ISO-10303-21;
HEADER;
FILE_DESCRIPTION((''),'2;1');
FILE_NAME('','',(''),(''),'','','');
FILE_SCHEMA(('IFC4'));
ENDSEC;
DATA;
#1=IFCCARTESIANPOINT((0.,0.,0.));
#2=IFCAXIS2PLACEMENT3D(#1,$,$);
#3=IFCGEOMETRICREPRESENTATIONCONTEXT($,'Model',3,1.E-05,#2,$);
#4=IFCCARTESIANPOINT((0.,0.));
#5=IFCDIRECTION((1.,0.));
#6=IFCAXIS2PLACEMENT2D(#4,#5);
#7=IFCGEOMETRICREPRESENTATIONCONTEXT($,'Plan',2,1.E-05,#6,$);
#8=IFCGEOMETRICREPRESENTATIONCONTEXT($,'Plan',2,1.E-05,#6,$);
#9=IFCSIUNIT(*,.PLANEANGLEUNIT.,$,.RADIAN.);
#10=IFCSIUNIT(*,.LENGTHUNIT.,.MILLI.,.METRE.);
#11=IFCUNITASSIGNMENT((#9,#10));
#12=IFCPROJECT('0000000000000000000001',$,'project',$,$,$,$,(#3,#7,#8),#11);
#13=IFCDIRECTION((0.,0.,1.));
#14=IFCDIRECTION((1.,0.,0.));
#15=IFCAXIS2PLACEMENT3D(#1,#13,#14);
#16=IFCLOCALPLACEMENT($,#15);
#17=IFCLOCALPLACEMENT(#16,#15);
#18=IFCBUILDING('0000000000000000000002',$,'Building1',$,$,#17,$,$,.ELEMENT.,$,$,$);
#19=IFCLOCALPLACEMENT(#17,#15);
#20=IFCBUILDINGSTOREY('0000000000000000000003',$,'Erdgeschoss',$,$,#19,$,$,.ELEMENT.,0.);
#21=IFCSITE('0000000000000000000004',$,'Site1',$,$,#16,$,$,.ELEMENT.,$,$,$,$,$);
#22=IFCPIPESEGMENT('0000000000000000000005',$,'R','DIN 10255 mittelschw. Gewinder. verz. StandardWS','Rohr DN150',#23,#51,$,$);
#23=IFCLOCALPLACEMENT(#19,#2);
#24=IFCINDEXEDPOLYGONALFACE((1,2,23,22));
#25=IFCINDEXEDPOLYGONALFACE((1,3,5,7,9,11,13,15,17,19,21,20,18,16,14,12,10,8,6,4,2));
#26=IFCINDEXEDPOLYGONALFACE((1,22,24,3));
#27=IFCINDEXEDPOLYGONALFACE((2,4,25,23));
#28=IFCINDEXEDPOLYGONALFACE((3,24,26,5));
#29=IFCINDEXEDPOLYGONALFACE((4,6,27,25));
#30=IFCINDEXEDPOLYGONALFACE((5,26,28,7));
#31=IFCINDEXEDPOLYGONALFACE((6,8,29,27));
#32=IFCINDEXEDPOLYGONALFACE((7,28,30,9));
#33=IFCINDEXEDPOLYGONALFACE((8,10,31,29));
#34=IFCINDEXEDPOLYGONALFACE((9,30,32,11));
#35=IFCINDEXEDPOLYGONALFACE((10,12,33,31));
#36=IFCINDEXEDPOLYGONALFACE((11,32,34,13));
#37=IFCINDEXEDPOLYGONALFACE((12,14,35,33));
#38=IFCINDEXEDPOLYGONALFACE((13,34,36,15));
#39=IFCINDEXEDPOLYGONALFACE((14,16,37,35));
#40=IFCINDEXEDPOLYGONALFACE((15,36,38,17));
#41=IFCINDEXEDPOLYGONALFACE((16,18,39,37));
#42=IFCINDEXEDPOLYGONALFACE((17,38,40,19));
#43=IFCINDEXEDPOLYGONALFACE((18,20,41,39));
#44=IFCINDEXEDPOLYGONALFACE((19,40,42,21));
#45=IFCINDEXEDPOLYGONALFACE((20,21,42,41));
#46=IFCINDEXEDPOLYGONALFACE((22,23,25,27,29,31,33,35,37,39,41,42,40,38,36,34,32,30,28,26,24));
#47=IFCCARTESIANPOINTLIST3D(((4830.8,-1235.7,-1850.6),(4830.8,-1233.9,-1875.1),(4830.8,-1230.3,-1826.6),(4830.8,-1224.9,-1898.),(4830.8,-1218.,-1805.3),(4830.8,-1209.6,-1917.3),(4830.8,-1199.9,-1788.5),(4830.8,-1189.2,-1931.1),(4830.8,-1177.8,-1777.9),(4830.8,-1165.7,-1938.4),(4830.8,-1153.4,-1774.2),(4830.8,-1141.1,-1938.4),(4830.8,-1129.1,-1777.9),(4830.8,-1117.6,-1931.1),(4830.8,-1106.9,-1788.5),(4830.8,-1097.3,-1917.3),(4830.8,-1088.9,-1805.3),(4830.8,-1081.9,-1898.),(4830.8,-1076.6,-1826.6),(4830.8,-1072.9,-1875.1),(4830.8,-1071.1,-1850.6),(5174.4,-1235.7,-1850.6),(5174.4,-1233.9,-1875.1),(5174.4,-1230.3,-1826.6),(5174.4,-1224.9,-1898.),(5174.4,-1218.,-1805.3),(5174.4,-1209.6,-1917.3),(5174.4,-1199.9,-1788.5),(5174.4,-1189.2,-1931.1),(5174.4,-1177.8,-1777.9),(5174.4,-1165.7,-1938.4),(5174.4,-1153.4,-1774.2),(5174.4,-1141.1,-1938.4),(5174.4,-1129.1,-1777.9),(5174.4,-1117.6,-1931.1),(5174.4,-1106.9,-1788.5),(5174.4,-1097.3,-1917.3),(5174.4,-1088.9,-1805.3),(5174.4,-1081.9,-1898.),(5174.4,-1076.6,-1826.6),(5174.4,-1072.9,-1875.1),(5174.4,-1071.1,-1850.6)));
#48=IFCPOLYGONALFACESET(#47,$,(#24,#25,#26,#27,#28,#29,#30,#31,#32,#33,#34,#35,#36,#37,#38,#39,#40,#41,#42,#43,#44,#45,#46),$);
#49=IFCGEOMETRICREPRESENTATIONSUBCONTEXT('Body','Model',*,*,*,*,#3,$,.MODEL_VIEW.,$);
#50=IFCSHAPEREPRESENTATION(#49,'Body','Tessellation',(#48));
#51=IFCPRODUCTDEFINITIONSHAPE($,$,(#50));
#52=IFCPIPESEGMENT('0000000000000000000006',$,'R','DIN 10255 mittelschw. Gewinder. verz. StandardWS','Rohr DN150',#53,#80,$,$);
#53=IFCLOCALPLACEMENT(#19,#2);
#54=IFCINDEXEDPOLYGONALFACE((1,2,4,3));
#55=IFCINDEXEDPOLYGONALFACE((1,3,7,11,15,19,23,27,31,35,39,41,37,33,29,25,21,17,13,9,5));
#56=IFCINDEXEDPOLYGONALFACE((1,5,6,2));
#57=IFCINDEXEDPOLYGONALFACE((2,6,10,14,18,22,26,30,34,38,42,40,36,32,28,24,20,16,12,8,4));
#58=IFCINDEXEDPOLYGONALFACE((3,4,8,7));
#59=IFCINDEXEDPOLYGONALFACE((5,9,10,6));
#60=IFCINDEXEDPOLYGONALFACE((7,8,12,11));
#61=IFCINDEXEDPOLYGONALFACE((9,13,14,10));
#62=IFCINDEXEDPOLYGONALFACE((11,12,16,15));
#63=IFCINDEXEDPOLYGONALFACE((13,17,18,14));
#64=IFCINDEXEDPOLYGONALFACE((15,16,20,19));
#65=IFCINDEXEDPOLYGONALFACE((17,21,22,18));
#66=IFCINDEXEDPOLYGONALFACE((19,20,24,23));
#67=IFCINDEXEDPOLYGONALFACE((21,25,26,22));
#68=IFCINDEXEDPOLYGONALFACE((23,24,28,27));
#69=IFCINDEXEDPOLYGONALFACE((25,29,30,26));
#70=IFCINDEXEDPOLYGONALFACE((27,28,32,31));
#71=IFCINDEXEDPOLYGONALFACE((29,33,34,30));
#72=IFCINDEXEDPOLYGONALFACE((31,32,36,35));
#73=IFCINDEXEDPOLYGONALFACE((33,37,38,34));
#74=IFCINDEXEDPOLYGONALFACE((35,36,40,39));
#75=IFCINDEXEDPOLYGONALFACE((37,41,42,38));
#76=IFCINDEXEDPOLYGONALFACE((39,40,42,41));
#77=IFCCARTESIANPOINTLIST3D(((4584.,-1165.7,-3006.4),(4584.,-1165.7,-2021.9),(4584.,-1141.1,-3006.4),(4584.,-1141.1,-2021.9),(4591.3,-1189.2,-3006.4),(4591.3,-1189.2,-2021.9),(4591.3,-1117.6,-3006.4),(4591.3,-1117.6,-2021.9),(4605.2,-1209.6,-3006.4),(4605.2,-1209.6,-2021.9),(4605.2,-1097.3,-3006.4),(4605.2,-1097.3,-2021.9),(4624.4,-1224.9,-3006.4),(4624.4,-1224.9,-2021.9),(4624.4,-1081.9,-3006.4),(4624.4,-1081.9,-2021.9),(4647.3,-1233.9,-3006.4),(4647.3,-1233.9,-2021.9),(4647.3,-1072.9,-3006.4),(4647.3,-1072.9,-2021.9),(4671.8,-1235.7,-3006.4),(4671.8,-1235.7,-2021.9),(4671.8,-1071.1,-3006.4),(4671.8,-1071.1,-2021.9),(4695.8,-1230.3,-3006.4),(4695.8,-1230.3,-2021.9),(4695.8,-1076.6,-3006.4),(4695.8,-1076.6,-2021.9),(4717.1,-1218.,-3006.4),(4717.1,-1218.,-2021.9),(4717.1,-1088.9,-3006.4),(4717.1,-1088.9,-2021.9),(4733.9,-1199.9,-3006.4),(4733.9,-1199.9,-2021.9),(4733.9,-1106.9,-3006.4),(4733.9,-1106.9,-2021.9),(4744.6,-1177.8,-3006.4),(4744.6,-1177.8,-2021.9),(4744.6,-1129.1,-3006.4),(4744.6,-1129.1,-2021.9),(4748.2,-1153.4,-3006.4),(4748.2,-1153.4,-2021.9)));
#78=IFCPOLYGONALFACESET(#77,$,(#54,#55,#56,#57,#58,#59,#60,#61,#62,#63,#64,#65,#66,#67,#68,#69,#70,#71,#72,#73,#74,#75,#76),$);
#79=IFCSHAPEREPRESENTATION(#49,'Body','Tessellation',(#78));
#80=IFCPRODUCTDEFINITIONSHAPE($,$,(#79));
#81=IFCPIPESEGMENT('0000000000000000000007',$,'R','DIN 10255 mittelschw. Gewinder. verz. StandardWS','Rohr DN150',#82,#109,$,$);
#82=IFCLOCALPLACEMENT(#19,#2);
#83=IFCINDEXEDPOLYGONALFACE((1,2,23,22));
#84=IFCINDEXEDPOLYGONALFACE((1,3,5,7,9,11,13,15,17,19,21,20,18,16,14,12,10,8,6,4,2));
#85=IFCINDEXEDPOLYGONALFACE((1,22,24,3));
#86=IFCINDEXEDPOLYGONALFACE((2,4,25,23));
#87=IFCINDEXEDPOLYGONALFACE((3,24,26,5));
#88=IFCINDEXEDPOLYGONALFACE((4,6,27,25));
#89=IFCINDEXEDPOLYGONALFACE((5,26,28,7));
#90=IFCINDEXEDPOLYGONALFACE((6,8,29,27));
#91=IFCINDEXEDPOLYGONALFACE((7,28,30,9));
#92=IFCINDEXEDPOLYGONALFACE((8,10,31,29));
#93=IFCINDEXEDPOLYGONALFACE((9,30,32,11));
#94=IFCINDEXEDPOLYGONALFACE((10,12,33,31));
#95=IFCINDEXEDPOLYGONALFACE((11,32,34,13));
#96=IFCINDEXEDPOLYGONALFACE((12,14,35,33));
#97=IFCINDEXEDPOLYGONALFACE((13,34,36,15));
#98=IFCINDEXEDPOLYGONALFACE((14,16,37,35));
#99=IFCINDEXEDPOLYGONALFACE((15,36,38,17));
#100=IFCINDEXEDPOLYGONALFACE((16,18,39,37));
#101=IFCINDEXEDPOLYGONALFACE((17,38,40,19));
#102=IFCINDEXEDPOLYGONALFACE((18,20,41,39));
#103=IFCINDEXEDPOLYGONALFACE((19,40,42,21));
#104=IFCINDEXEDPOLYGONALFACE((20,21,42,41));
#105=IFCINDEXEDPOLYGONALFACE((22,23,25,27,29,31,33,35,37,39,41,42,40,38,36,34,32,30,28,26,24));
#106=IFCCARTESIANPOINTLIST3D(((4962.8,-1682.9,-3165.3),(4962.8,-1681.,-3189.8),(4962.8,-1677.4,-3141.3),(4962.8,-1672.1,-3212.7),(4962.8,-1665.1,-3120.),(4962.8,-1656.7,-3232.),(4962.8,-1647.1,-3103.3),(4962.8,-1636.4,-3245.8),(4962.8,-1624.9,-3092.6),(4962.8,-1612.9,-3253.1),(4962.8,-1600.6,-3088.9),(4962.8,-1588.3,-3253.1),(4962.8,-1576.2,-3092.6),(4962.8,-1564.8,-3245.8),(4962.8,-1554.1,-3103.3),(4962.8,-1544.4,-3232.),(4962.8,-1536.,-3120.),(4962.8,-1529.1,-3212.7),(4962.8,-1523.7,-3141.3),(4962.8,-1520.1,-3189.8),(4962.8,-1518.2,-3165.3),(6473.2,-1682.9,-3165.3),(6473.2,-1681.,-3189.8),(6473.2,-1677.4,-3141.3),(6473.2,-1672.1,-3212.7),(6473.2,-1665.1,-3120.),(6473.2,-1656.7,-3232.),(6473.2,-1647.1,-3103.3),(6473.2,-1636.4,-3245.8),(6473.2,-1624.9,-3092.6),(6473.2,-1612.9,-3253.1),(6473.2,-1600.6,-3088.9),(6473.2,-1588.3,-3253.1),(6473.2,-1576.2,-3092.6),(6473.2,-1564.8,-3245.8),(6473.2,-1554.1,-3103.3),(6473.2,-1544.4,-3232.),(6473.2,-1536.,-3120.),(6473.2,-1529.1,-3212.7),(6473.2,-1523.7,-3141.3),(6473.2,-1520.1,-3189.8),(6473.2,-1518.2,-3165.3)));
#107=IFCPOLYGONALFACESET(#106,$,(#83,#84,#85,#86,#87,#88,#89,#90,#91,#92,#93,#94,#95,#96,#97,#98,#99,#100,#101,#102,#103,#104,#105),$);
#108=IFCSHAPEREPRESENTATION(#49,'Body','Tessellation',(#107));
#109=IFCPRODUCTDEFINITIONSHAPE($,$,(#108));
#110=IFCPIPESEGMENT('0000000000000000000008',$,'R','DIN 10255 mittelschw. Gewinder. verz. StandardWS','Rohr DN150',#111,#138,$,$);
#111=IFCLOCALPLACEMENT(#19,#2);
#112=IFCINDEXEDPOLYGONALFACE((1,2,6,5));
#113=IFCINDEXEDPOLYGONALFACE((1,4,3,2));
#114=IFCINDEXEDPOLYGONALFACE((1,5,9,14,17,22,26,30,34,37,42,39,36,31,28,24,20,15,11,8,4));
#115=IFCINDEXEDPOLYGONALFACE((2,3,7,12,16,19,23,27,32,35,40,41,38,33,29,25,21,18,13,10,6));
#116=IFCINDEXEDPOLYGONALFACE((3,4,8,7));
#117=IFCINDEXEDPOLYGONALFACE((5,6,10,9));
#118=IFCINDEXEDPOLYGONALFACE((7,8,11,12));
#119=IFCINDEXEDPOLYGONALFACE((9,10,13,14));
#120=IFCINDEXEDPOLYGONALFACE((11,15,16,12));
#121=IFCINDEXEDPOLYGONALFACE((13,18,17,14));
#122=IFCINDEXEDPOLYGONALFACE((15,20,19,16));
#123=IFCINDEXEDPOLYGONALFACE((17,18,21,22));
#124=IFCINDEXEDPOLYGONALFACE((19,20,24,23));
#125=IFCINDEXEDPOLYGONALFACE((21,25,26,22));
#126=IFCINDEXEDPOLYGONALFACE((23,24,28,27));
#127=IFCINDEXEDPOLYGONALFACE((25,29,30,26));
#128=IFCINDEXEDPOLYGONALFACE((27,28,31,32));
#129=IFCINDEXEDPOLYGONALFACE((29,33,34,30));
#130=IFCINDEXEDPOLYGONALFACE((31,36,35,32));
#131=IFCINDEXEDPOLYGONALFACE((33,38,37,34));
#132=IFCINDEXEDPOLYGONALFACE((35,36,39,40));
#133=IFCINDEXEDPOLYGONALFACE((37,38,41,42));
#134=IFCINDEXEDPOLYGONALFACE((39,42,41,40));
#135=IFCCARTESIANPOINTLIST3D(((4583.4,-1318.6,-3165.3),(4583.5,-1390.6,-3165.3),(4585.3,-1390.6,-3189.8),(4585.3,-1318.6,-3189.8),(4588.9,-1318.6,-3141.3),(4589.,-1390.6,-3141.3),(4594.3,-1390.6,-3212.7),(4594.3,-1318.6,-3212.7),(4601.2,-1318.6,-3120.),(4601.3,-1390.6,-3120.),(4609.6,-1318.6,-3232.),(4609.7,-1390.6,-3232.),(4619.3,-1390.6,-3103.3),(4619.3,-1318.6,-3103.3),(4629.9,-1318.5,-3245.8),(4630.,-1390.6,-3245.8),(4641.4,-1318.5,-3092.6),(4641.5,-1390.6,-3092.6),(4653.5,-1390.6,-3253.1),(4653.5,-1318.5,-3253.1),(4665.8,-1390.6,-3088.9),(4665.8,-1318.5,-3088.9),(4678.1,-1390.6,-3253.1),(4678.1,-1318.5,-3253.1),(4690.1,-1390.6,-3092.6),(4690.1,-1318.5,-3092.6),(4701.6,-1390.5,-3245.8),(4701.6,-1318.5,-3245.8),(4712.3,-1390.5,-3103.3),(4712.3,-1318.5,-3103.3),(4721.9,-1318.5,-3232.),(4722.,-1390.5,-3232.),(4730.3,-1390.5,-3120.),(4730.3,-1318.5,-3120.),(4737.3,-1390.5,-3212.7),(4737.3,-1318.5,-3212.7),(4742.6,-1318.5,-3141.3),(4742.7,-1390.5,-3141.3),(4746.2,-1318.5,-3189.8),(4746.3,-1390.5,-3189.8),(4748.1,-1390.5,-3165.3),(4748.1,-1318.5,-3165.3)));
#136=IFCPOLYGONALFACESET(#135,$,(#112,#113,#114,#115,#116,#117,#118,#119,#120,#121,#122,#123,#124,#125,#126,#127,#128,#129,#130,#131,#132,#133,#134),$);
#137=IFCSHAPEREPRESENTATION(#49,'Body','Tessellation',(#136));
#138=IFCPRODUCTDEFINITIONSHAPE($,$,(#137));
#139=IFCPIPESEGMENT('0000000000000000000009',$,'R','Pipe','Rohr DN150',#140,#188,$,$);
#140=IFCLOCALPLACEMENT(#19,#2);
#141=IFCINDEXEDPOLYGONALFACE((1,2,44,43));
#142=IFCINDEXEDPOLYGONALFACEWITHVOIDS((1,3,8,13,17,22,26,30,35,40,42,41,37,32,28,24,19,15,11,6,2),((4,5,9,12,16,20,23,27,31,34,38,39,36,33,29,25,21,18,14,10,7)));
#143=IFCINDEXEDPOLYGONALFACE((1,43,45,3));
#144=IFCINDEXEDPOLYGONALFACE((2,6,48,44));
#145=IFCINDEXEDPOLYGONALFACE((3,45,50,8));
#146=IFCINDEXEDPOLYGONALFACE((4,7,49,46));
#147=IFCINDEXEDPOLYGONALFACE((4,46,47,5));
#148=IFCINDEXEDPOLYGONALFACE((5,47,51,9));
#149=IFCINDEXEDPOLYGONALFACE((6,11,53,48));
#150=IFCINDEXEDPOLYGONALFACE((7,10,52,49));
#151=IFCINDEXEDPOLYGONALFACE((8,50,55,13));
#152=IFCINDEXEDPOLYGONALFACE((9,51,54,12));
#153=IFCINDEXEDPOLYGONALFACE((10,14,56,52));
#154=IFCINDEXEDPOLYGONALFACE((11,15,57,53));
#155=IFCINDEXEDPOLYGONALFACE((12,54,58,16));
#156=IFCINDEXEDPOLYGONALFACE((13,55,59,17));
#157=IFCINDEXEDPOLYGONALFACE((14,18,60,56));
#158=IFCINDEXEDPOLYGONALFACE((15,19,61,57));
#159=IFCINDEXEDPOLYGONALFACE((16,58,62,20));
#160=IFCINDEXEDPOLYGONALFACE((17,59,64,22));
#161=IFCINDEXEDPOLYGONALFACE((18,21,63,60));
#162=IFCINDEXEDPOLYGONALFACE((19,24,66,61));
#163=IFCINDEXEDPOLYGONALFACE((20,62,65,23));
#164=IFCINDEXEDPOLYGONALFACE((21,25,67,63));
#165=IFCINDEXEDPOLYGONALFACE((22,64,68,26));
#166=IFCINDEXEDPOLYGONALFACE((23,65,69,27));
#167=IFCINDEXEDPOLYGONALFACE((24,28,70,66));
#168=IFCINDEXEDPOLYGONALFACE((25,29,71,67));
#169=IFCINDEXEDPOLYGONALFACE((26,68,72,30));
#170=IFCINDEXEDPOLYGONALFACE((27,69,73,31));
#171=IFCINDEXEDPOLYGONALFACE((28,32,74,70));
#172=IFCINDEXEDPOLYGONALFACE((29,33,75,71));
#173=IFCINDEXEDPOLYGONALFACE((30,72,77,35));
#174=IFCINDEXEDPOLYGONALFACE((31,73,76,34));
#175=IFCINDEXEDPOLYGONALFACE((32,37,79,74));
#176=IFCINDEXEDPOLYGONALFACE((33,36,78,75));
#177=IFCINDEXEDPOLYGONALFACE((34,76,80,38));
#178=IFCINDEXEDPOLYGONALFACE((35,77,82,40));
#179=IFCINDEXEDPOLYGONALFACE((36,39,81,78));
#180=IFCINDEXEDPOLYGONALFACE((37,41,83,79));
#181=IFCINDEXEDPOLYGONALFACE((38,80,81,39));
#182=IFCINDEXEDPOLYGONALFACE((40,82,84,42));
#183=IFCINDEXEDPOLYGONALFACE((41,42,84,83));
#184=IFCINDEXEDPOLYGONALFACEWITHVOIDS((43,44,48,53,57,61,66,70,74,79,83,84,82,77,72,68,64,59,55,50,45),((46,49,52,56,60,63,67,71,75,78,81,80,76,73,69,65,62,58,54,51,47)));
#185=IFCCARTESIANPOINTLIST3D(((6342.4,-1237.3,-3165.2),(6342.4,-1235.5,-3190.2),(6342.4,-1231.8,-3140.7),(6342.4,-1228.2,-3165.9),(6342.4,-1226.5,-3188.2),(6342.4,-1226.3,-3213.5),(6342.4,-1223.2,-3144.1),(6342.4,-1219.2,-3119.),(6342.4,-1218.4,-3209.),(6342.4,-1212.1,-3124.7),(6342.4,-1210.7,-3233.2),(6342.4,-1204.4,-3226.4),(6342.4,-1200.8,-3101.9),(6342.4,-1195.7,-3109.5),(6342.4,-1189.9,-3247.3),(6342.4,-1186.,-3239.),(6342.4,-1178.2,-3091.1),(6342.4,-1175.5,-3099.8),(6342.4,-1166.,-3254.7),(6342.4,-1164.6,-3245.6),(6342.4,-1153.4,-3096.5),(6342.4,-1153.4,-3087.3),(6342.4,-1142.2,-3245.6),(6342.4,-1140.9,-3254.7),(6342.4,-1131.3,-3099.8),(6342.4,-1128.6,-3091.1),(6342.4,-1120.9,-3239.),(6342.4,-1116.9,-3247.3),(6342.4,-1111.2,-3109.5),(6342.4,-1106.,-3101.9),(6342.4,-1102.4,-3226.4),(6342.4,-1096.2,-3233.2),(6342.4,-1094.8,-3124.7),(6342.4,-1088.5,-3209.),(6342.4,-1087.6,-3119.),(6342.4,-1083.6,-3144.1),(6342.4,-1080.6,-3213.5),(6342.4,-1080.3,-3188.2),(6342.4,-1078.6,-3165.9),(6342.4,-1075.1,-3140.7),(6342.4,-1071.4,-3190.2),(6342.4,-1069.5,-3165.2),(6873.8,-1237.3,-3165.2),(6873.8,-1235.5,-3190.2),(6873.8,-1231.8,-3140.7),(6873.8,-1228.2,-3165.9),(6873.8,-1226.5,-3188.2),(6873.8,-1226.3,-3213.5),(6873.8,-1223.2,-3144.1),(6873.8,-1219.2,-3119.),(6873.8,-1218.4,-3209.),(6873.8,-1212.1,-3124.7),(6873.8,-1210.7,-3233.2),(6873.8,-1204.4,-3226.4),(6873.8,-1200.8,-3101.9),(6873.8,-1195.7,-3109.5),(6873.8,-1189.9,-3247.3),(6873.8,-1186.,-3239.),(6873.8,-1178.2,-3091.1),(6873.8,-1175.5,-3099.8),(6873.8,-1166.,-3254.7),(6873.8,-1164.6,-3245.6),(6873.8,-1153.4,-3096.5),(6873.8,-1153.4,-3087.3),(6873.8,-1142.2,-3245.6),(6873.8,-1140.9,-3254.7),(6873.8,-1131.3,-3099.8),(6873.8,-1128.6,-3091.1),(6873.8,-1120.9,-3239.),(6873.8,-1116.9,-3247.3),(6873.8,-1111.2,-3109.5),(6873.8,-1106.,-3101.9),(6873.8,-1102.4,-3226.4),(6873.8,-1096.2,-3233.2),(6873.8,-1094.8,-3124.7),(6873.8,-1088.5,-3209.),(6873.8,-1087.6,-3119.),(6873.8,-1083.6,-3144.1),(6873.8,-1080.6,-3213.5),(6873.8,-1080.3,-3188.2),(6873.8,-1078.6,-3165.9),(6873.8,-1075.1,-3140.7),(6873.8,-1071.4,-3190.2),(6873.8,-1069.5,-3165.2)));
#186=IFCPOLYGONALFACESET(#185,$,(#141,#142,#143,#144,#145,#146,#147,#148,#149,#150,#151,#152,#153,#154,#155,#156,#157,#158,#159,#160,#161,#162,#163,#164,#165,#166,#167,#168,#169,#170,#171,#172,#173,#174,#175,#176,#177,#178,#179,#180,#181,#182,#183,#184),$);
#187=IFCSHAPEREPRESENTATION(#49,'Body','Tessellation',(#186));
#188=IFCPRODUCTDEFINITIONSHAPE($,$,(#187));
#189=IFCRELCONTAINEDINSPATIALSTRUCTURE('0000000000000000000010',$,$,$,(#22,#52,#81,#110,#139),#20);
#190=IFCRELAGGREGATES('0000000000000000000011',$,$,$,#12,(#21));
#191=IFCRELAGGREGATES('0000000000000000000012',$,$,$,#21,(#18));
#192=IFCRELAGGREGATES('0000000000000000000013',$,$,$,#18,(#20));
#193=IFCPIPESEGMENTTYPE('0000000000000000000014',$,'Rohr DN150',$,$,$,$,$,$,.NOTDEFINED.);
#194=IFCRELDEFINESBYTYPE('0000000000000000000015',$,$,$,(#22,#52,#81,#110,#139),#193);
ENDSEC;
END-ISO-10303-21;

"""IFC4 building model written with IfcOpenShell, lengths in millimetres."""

from ifc_helpers import new_model, si_unit, frame, origin, origin_with_axes, origin_2d_with_axis, place, context, subcontext, project, spatial, circle, hollow_circle, extrude, type_object, element, save


model = new_model("IFC4")

# Units and contexts
model_context = context("Model", 3, precision=1e-05, world=origin())
plan_context_1 = context("Plan", 2, precision=1e-05, world=origin_2d_with_axis())
plan_context_2 = context("Plan", 2, precision=1e-05, world=origin_2d_with_axis())
body_context = subcontext(model_context, "Body", "Model", "MODEL_VIEW")
ifc_project = project(units=[si_unit("PLANEANGLEUNIT", "RADIAN"), si_unit("LENGTHUNIT", "METRE", prefix="MILLI")], contexts=[model_context, plan_context_1, plan_context_2])

# Site, building, storey
site_placement = place(None, origin_with_axes())
site = spatial("IfcSite", under=ifc_project, at=site_placement, Name="Site1", CompositionType="ELEMENT")
building_placement = place(site_placement, origin_with_axes())
building = spatial("IfcBuilding", under=site, at=building_placement, Name="Building1", CompositionType="ELEMENT")
storey_placement = place(building_placement, origin_with_axes())
storey = spatial("IfcBuildingStorey", under=building, at=storey_placement, Name="Erdgeschoss", CompositionType="ELEMENT", Elevation=0.0)

# Pipe segments
pipe_segment_type_1 = type_object("IfcPipeSegmentType", Name="Rohr DN150", PredefinedType="NOTDEFINED")
pipe_segment_1_placement = place(storey_placement, frame((5002.6, -1153.6, -1856.8), z_axis=(0.0, 0.0, 1.0), x_axis=(1.0, 0.0, 0.0)))
element("IfcPipeSegment", 1, at=pipe_segment_1_placement, inside=storey, type_object=pipe_segment_type_1, Name="R", Description="DIN 10255 mittelschw. Gewinder. verz. StandardWS", ObjectType="Rohr DN150", context=body_context, shape_type="SolidModel", body=[
    extrude(circle(Radius=82.5, at=origin_2d_with_axis()), frame((171.8, 0.2, 0.0), z_axis=(-1.0, 0.0, 0.0), x_axis=(0.0, 0.0, 1.0)), (0.0, 0.0, 1.0), 343.6),
])
pipe_segment_2_placement = place(storey_placement, frame((4665.7, -1153.6, -2514.1), z_axis=(0.0, 0.0, 1.0), x_axis=(1.0, 0.0, 0.0)))
element("IfcPipeSegment", 2, at=pipe_segment_2_placement, inside=storey, type_object=pipe_segment_type_1, Name="R", Description="DIN 10255 mittelschw. Gewinder. verz. StandardWS", ObjectType="Rohr DN150", context=body_context, shape_type="SolidModel", body=[
    extrude(circle(Radius=82.5, at=origin_2d_with_axis()), frame((0.0, 0.2, -492.3), z_axis=(0.0, 0.0, 1.0), x_axis=(1.0, 0.0, 0.0)), (0.0, 0.0, 1.0), 984.5),
])
pipe_segment_3_placement = place(storey_placement, frame((5718.0, -1600.7, -3171.5), z_axis=(0.0, 0.0, 1.0), x_axis=(1.0, 0.0, 0.0)))
element("IfcPipeSegment", 3, at=pipe_segment_3_placement, inside=storey, type_object=pipe_segment_type_1, Name="R", Description="DIN 10255 mittelschw. Gewinder. verz. StandardWS", ObjectType="Rohr DN150", context=body_context, shape_type="SolidModel", body=[
    extrude(circle(Radius=82.5, at=origin_2d_with_axis()), frame((755.2, 0.1, 0.0), z_axis=(-1.0, 0.0, 0.0), x_axis=(0.0, 0.0, 1.0)), (0.0, 0.0, 1.0), 1510.4),
])
pipe_segment_4_placement = place(storey_placement, frame((4665.6, -1354.5, -3171.5), z_axis=(0.0, 0.0, 1.0), x_axis=(1.0, 0.0, 0.0)))
element("IfcPipeSegment", 4, at=pipe_segment_4_placement, inside=storey, type_object=pipe_segment_type_1, Name="R", Description="DIN 10255 mittelschw. Gewinder. verz. StandardWS", ObjectType="Rohr DN150", context=body_context, shape_type="SolidModel", body=[
    extrude(circle(Radius=82.5, at=origin_2d_with_axis()), frame((0.2, -36.0, 0.0), z_axis=(-0.000562, 1.0, 0.0), x_axis=(0.0, 0.0, 1.0)), (0.0, 0.0, 1.0), 72.0),
])
pipe_segment_5_placement = place(storey_placement, frame((6608.1, -1153.6, -3171.5), z_axis=(0.0, 0.0, 1.0), x_axis=(1.0, 0.0, 0.0)))
element("IfcPipeSegment", 5, at=pipe_segment_5_placement, inside=storey, type_object=pipe_segment_type_1, Name="R", Description="Pipe", ObjectType="Rohr DN150", context=body_context, shape_type="SolidModel", body=[
    extrude(hollow_circle(Radius=84.2, WallThickness=9.2, at=origin_2d_with_axis()), frame((265.7, 0.1, 0.0), z_axis=(-1.0, 0.0, 0.0), x_axis=(0.0, 0.0, 1.0)), (0.0, 0.0, 1.0), 531.3),
])

save(model, "model.ifc")
